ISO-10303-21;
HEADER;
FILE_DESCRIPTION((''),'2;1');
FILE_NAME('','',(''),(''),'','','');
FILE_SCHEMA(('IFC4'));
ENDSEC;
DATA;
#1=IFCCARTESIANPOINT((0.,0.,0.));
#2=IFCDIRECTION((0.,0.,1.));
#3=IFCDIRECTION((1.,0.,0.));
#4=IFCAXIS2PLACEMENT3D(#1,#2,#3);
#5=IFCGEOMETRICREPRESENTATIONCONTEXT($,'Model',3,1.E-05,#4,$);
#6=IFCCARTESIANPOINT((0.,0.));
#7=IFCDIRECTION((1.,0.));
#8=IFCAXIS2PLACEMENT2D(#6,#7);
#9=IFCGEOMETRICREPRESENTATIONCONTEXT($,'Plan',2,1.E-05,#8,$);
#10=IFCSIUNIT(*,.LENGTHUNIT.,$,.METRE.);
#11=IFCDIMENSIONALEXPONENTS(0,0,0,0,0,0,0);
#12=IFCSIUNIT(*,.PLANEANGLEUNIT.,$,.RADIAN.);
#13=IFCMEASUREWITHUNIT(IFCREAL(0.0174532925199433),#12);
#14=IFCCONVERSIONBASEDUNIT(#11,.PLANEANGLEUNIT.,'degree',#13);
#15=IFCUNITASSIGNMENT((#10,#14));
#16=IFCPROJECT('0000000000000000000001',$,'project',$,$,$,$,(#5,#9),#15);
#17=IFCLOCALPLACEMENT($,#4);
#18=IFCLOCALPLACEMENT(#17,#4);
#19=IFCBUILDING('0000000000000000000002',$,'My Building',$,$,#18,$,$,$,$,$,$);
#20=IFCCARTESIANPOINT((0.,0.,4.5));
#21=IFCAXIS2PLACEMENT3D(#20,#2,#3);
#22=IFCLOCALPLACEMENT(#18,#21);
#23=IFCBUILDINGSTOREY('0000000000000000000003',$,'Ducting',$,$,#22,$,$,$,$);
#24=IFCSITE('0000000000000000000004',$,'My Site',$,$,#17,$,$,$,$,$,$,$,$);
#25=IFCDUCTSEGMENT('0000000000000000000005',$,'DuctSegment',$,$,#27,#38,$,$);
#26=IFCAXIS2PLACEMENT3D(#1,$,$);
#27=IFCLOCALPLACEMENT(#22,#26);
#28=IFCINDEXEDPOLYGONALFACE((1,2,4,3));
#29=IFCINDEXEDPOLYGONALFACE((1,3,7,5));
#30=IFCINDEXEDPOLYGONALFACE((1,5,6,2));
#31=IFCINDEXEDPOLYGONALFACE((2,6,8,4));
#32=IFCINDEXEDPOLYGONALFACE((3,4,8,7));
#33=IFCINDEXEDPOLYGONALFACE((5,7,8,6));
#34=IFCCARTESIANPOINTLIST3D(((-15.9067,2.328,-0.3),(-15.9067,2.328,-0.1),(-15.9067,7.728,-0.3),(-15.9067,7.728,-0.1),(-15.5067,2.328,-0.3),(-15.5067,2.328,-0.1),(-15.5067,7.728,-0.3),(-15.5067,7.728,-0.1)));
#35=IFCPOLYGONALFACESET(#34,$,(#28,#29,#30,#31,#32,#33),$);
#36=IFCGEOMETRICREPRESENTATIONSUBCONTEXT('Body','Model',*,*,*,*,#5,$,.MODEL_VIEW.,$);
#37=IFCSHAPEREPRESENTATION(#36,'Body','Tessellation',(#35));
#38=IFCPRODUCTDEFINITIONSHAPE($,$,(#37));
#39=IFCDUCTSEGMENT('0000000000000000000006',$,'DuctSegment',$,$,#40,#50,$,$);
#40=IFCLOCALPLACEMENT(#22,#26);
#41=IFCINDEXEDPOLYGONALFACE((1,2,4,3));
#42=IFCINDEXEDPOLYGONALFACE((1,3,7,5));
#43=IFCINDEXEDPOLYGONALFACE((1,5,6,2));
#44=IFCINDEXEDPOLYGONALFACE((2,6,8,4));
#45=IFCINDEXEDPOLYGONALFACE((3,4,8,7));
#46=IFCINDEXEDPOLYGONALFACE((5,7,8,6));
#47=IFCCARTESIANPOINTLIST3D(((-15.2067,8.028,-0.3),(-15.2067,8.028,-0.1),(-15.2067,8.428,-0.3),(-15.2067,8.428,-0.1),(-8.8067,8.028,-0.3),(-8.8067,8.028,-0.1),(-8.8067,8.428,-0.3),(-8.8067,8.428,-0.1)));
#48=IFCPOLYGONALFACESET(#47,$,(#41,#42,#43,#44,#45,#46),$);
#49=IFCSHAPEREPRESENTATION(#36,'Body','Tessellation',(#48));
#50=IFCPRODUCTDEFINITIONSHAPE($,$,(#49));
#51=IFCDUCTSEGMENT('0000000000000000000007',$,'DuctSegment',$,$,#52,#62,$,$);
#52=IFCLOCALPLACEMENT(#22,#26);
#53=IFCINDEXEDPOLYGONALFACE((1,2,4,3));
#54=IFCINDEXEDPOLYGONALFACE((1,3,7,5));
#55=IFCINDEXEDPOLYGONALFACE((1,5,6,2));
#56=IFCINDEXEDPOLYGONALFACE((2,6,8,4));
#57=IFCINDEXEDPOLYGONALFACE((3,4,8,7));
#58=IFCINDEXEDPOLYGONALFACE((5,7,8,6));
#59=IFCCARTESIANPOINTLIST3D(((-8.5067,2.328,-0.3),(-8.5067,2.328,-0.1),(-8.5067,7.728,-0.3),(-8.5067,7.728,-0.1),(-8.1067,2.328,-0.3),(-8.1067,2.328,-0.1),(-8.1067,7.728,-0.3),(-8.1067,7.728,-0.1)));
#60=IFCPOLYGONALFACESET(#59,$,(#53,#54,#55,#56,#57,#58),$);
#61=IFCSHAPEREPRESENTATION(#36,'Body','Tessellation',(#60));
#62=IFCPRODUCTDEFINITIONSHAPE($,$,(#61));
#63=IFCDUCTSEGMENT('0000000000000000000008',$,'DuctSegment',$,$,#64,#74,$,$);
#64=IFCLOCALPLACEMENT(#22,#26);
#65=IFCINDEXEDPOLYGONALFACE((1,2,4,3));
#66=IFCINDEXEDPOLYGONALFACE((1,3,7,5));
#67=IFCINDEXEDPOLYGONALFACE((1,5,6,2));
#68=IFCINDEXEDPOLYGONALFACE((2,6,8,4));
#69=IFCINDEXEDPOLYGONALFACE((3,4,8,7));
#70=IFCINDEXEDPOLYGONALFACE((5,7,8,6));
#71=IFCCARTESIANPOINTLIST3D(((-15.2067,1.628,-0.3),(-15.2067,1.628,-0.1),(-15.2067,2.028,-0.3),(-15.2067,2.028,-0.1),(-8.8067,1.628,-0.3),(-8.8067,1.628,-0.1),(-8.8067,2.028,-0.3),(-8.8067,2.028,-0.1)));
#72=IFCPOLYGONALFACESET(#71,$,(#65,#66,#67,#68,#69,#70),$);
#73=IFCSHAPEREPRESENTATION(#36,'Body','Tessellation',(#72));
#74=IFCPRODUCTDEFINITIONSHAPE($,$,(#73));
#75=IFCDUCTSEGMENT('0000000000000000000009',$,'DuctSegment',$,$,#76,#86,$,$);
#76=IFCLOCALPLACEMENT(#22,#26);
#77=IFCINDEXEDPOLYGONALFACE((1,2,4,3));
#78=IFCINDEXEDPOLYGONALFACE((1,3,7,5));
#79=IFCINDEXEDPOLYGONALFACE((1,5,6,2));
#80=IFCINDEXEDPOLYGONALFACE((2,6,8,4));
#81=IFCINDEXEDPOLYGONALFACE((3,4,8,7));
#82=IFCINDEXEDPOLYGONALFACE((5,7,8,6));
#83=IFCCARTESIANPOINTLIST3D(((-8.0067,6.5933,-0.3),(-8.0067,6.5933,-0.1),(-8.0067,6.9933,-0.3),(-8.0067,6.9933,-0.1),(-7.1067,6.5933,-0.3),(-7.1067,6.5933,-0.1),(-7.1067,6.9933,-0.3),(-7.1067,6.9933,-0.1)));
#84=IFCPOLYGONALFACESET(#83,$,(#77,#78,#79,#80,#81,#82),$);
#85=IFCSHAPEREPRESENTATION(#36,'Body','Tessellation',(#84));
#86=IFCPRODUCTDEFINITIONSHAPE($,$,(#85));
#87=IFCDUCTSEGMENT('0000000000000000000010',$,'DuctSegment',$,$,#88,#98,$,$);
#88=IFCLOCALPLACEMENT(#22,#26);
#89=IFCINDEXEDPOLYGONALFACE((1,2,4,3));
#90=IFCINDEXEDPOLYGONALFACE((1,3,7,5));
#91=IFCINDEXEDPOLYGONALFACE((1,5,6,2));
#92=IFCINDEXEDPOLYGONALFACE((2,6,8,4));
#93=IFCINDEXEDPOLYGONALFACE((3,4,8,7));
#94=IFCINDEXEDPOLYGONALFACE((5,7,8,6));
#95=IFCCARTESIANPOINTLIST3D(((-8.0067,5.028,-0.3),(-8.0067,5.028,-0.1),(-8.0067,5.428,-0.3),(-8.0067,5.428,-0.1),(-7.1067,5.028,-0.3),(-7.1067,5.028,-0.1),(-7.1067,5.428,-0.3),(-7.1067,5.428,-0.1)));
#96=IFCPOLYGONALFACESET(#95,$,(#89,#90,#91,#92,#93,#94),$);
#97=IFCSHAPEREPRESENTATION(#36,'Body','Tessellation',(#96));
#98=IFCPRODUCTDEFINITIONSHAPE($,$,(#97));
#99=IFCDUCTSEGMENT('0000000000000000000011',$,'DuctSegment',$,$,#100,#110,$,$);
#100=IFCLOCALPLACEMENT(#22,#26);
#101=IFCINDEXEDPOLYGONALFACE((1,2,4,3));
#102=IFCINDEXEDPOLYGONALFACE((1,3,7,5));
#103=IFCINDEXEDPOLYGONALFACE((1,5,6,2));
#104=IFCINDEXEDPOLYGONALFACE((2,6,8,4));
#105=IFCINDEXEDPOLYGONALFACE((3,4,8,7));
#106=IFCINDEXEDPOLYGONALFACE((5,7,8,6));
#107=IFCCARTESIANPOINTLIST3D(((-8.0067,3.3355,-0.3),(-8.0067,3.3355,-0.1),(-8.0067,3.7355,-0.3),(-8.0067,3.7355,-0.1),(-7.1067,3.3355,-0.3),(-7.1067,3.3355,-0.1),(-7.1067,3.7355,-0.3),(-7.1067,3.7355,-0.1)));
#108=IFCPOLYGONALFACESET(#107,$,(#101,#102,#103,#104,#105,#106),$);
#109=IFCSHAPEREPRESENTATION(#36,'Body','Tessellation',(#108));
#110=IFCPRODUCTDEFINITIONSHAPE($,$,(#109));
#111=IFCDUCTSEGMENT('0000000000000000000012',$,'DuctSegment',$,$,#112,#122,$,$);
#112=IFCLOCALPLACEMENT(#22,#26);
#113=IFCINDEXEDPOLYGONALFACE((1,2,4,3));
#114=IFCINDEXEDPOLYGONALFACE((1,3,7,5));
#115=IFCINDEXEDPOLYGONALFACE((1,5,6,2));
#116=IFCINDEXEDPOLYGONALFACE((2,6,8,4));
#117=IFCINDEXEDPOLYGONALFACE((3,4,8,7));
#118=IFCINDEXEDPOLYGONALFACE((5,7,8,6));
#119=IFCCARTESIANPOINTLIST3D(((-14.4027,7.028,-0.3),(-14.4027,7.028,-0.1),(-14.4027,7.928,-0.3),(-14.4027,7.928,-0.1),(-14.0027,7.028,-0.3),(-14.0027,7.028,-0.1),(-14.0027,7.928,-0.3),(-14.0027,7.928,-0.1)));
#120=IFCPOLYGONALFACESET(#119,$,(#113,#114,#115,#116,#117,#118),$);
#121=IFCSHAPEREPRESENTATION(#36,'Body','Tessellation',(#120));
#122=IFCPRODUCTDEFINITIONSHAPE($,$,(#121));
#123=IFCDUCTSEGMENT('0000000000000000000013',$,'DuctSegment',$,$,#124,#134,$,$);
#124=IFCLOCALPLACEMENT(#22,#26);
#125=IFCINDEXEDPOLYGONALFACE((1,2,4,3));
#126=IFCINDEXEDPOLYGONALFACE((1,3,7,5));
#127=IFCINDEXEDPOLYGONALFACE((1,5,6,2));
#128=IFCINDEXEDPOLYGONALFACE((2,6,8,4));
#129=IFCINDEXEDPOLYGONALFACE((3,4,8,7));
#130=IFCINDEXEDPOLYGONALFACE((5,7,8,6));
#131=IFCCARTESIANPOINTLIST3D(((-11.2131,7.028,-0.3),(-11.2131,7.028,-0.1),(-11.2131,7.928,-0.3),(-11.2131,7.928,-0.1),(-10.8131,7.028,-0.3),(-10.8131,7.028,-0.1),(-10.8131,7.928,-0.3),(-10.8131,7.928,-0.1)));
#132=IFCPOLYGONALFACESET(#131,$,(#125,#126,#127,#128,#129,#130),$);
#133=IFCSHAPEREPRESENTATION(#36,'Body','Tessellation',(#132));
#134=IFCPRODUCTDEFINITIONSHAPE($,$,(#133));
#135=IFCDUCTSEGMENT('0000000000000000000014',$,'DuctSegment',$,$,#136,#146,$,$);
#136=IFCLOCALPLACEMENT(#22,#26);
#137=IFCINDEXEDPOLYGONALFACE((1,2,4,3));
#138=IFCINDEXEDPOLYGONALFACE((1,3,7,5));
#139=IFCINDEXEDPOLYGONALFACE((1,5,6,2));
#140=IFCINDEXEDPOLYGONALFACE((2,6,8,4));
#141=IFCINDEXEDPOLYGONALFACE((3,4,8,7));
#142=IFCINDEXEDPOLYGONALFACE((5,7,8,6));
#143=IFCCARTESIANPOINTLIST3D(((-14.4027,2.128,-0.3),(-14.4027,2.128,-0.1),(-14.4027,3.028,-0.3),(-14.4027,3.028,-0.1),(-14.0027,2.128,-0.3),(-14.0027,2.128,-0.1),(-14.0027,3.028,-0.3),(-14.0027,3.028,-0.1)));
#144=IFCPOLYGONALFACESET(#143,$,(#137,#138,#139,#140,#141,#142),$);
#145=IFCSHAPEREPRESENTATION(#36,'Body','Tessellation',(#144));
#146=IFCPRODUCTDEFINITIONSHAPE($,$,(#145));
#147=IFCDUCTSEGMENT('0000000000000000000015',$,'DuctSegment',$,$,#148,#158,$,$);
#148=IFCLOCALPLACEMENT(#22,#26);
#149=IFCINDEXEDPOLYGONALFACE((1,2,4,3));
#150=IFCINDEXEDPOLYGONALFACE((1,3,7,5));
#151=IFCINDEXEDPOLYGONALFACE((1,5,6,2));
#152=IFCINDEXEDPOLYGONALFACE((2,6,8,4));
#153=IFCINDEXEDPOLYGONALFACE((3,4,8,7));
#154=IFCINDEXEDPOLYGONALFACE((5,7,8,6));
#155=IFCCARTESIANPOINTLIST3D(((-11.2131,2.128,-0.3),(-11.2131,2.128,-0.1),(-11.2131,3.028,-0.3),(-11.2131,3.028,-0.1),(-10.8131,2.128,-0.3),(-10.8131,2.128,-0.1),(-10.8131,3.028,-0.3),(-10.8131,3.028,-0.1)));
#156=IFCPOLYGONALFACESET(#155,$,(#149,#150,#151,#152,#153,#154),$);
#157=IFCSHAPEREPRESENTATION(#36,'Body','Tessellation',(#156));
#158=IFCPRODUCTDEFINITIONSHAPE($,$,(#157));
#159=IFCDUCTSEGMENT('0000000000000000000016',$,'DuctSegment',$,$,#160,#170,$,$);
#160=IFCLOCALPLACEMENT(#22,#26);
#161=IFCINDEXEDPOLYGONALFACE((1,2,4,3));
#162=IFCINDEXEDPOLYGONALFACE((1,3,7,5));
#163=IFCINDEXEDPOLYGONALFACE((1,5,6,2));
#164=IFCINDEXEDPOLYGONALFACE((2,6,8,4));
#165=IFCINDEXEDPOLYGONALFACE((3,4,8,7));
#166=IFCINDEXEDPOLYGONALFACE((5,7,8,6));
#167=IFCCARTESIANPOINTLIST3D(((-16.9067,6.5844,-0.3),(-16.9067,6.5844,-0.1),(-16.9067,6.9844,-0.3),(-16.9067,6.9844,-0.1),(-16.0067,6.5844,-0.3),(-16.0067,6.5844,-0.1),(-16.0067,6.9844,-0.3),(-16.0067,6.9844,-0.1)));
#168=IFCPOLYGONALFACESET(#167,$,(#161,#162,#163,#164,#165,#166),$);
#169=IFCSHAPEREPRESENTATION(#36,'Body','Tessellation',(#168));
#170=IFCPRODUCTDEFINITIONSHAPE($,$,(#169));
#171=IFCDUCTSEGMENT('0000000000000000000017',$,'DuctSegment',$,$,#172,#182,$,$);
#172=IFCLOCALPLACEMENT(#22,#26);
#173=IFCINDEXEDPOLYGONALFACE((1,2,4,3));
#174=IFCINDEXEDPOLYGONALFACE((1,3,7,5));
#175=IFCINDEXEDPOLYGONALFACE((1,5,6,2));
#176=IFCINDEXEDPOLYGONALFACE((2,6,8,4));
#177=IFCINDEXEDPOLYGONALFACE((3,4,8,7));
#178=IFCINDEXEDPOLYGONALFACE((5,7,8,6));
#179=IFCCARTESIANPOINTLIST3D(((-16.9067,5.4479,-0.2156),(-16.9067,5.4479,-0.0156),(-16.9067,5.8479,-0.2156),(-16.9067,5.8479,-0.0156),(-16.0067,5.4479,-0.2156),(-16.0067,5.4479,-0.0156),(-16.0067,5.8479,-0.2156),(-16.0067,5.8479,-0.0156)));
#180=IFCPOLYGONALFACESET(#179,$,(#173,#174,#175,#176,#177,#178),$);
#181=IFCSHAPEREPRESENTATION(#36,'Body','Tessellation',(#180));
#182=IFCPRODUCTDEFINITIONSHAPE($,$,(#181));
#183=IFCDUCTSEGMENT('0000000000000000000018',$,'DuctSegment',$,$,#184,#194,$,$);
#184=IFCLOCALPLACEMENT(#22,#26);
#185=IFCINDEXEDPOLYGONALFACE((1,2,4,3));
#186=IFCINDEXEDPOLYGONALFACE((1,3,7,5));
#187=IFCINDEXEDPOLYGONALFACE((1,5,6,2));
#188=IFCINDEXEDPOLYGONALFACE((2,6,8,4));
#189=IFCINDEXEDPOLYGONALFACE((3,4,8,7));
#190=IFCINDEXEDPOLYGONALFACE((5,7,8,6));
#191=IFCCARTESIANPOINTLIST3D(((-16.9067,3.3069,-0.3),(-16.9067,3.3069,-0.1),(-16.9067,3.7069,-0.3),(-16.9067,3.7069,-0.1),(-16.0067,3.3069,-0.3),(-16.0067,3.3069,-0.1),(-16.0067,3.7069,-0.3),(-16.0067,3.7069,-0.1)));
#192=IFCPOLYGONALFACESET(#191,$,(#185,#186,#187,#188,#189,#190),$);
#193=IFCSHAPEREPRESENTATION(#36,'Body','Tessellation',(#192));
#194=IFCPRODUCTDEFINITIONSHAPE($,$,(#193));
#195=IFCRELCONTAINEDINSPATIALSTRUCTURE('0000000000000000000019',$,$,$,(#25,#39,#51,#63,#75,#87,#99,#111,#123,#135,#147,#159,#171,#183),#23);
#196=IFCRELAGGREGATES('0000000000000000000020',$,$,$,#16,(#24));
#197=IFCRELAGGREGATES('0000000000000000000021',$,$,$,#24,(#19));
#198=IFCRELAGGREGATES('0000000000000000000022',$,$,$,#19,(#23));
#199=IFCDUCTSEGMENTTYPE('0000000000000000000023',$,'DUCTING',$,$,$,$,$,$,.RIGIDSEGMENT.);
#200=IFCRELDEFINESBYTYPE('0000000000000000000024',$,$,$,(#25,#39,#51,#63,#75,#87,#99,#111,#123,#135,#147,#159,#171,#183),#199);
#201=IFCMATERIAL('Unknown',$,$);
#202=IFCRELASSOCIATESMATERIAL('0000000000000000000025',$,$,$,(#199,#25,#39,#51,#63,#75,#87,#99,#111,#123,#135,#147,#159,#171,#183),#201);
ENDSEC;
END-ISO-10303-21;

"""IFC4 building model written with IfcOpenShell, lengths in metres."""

from ifc_helpers import new_model, entity, si_unit, converted_unit, frame, origin_with_axes, origin_2d_with_axis, place, context, subcontext, project, spatial, rectangle, extrude, material, material_profile, profile_set, profile_usage, type_object, element, save


model = new_model("IFC4")

# Units and contexts
model_context = context("Model", 3, precision=1e-05, world=origin_with_axes())
plan_context = context("Plan", 2, precision=1e-05, world=origin_2d_with_axis())
body_context = subcontext(model_context, "Body", "Model", "MODEL_VIEW")
ifc_project = project(units=[si_unit("LENGTHUNIT", "METRE"), converted_unit("PLANEANGLEUNIT", "degree", entity("IfcReal", 0.0174532925199433), si_unit("PLANEANGLEUNIT", "RADIAN"), dimensions=[0, 0, 0, 0, 0, 0, 0])], contexts=[model_context, plan_context])

# Site, building, storey
site_placement = place(None, origin_with_axes())
site = spatial("IfcSite", under=ifc_project, at=site_placement, Name="My Site")
building_placement = place(site_placement, origin_with_axes())
building = spatial("IfcBuilding", under=site, at=building_placement, Name="My Building")
storey_placement = place(building_placement, frame((0.0, 0.0, 4.5), z_axis=(0.0, 0.0, 1.0), x_axis=(1.0, 0.0, 0.0)))
storey = spatial("IfcBuildingStorey", under=building, at=storey_placement, Name="Ducting")

# Duct segments
ifc_material = material(Name="Unknown")
ifc_material_profile_1 = material_profile(ifc_material, rectangle(XDim=0.4, YDim=0.2))
ifc_profile_set_1 = profile_set([ifc_material_profile_1])
ifc_profile_usage_1 = profile_usage(ifc_profile_set_1, cardinal=5)
duct_segment_type = type_object("IfcDuctSegmentType", Name="DUCTING", PredefinedType="RIGIDSEGMENT", material=ifc_profile_set_1)
duct_segment_1_placement = place(storey_placement, frame((-15.7067, 2.328, -0.2), z_axis=(0.0, 1.0, 0.0), x_axis=(-1.0, 0.0, 0.0)))
element("IfcDuctSegment", 1, at=duct_segment_1_placement, inside=storey, type_object=duct_segment_type, material=ifc_profile_usage_1, Name="DuctSegment", context=body_context, shape_type="SweptSolid", body=[
    extrude(rectangle(XDim=0.4, YDim=0.2), origin_with_axes(), (0.0, 0.0, 1.0), 5.4),
])
ifc_profile_usage_2 = profile_usage(ifc_profile_set_1, cardinal=5)
duct_segment_2_placement = place(storey_placement, frame((-15.2067, 8.228, -0.2), z_axis=(1.0, 0.0, 0.0), x_axis=(0.0, 1.0, 0.0)))
element("IfcDuctSegment", 2, at=duct_segment_2_placement, inside=storey, type_object=duct_segment_type, material=ifc_profile_usage_2, Name="DuctSegment", context=body_context, shape_type="SweptSolid", body=[
    extrude(rectangle(XDim=0.4, YDim=0.2), origin_with_axes(), (0.0, 0.0, 1.0), 6.4),
])
ifc_profile_usage_3 = profile_usage(ifc_profile_set_1, cardinal=5)
duct_segment_3_placement = place(storey_placement, frame((-8.3067, 2.328, -0.2), z_axis=(0.0, 1.0, 0.0), x_axis=(-1.0, 0.0, 0.0)))
element("IfcDuctSegment", 3, at=duct_segment_3_placement, inside=storey, type_object=duct_segment_type, material=ifc_profile_usage_3, Name="DuctSegment", context=body_context, shape_type="SweptSolid", body=[
    extrude(rectangle(XDim=0.4, YDim=0.2), origin_with_axes(), (0.0, 0.0, 1.0), 5.4),
])
ifc_profile_usage_4 = profile_usage(ifc_profile_set_1, cardinal=5)
duct_segment_4_placement = place(storey_placement, frame((-15.2067, 1.828, -0.2), z_axis=(1.0, 0.0, 0.0), x_axis=(0.0, 1.0, 0.0)))
element("IfcDuctSegment", 4, at=duct_segment_4_placement, inside=storey, type_object=duct_segment_type, material=ifc_profile_usage_4, Name="DuctSegment", context=body_context, shape_type="SweptSolid", body=[
    extrude(rectangle(XDim=0.4, YDim=0.2), origin_with_axes(), (0.0, 0.0, 1.0), 6.4),
])
ifc_profile_usage_5 = profile_usage(ifc_profile_set_1, cardinal=5)
duct_segment_5_placement = place(storey_placement, frame((-7.1067, 6.7933, -0.2), z_axis=(-1.0, 0.0, 0.0), x_axis=(0.0, -1.0, 0.0)))
element("IfcDuctSegment", 5, at=duct_segment_5_placement, inside=storey, type_object=duct_segment_type, material=ifc_profile_usage_5, Name="DuctSegment", context=body_context, shape_type="SweptSolid", body=[
    extrude(rectangle(XDim=0.4, YDim=0.2), origin_with_axes(), (0.0, 0.0, 1.0), 0.9),
])
ifc_profile_usage_6 = profile_usage(ifc_profile_set_1, cardinal=5)
duct_segment_6_placement = place(storey_placement, frame((-7.1067, 5.228, -0.2), z_axis=(-1.0, 0.0, 0.0), x_axis=(0.0, -1.0, 0.0)))
element("IfcDuctSegment", 6, at=duct_segment_6_placement, inside=storey, type_object=duct_segment_type, material=ifc_profile_usage_6, Name="DuctSegment", context=body_context, shape_type="SweptSolid", body=[
    extrude(rectangle(XDim=0.4, YDim=0.2), origin_with_axes(), (0.0, 0.0, 1.0), 0.9),
])
ifc_profile_usage_7 = profile_usage(ifc_profile_set_1, cardinal=5)
duct_segment_7_placement = place(storey_placement, frame((-7.1067, 3.5355, -0.2), z_axis=(-1.0, 0.0, 0.0), x_axis=(0.0, -1.0, 0.0)))
element("IfcDuctSegment", 7, at=duct_segment_7_placement, inside=storey, type_object=duct_segment_type, material=ifc_profile_usage_7, Name="DuctSegment", context=body_context, shape_type="SweptSolid", body=[
    extrude(rectangle(XDim=0.4, YDim=0.2), origin_with_axes(), (0.0, 0.0, 1.0), 0.9),
])
ifc_profile_usage_8 = profile_usage(ifc_profile_set_1, cardinal=5)
duct_segment_8_placement = place(storey_placement, frame((-14.2027, 7.028, -0.2), z_axis=(0.0, 1.0, 0.0), x_axis=(-1.0, 0.0, 0.0)))
element("IfcDuctSegment", 8, at=duct_segment_8_placement, inside=storey, type_object=duct_segment_type, material=ifc_profile_usage_8, Name="DuctSegment", context=body_context, shape_type="SweptSolid", body=[
    extrude(rectangle(XDim=0.4, YDim=0.2), origin_with_axes(), (0.0, 0.0, 1.0), 0.9),
])
ifc_profile_usage_9 = profile_usage(ifc_profile_set_1, cardinal=5)
duct_segment_9_placement = place(storey_placement, frame((-11.0131, 7.028, -0.2), z_axis=(0.0, 1.0, 0.0), x_axis=(-1.0, 0.0, 0.0)))
element("IfcDuctSegment", 9, at=duct_segment_9_placement, inside=storey, type_object=duct_segment_type, material=ifc_profile_usage_9, Name="DuctSegment", context=body_context, shape_type="SweptSolid", body=[
    extrude(rectangle(XDim=0.4, YDim=0.2), origin_with_axes(), (0.0, 0.0, 1.0), 0.9),
])
ifc_profile_usage_10 = profile_usage(ifc_profile_set_1, cardinal=5)
duct_segment_10_placement = place(storey_placement, frame((-14.2027, 2.128, -0.2), z_axis=(0.0, 1.0, 0.0), x_axis=(-1.0, 0.0, 0.0)))
element("IfcDuctSegment", 10, at=duct_segment_10_placement, inside=storey, type_object=duct_segment_type, material=ifc_profile_usage_10, Name="DuctSegment", context=body_context, shape_type="SweptSolid", body=[
    extrude(rectangle(XDim=0.4, YDim=0.2), origin_with_axes(), (0.0, 0.0, 1.0), 0.9),
])
ifc_profile_usage_11 = profile_usage(ifc_profile_set_1, cardinal=5)
duct_segment_11_placement = place(storey_placement, frame((-11.0131, 2.128, -0.2), z_axis=(0.0, 1.0, 0.0), x_axis=(-1.0, 0.0, 0.0)))
element("IfcDuctSegment", 11, at=duct_segment_11_placement, inside=storey, type_object=duct_segment_type, material=ifc_profile_usage_11, Name="DuctSegment", context=body_context, shape_type="SweptSolid", body=[
    extrude(rectangle(XDim=0.4, YDim=0.2), origin_with_axes(), (0.0, 0.0, 1.0), 0.9),
])
ifc_profile_usage_12 = profile_usage(ifc_profile_set_1, cardinal=5)
duct_segment_12_placement = place(storey_placement, frame((-16.0067, 6.7844, -0.2), z_axis=(-1.0, 0.0, 0.0), x_axis=(0.0, -1.0, 0.0)))
element("IfcDuctSegment", 12, at=duct_segment_12_placement, inside=storey, type_object=duct_segment_type, material=ifc_profile_usage_12, Name="DuctSegment", context=body_context, shape_type="SweptSolid", body=[
    extrude(rectangle(XDim=0.4, YDim=0.2), origin_with_axes(), (0.0, 0.0, 1.0), 0.9),
])
ifc_profile_usage_13 = profile_usage(ifc_profile_set_1, cardinal=5)
duct_segment_13_placement = place(storey_placement, frame((-16.0067, 5.6479, -0.1156), z_axis=(-1.0, 0.0, 0.0), x_axis=(0.0, -1.0, 0.0)))
element("IfcDuctSegment", 13, at=duct_segment_13_placement, inside=storey, type_object=duct_segment_type, material=ifc_profile_usage_13, Name="DuctSegment", context=body_context, shape_type="SweptSolid", body=[
    extrude(rectangle(XDim=0.4, YDim=0.2), origin_with_axes(), (0.0, 0.0, 1.0), 0.9),
])
ifc_profile_usage_14 = profile_usage(ifc_profile_set_1, cardinal=5)
duct_segment_14_placement = place(storey_placement, frame((-16.0067, 3.5069, -0.2), z_axis=(-1.0, 0.0, 0.0), x_axis=(0.0, -1.0, 0.0)))
element("IfcDuctSegment", 14, at=duct_segment_14_placement, inside=storey, type_object=duct_segment_type, material=ifc_profile_usage_14, Name="DuctSegment", context=body_context, shape_type="SweptSolid", body=[
    extrude(rectangle(XDim=0.4, YDim=0.2), origin_with_axes(), (0.0, 0.0, 1.0), 0.9),
])

save(model, "model.ifc")
